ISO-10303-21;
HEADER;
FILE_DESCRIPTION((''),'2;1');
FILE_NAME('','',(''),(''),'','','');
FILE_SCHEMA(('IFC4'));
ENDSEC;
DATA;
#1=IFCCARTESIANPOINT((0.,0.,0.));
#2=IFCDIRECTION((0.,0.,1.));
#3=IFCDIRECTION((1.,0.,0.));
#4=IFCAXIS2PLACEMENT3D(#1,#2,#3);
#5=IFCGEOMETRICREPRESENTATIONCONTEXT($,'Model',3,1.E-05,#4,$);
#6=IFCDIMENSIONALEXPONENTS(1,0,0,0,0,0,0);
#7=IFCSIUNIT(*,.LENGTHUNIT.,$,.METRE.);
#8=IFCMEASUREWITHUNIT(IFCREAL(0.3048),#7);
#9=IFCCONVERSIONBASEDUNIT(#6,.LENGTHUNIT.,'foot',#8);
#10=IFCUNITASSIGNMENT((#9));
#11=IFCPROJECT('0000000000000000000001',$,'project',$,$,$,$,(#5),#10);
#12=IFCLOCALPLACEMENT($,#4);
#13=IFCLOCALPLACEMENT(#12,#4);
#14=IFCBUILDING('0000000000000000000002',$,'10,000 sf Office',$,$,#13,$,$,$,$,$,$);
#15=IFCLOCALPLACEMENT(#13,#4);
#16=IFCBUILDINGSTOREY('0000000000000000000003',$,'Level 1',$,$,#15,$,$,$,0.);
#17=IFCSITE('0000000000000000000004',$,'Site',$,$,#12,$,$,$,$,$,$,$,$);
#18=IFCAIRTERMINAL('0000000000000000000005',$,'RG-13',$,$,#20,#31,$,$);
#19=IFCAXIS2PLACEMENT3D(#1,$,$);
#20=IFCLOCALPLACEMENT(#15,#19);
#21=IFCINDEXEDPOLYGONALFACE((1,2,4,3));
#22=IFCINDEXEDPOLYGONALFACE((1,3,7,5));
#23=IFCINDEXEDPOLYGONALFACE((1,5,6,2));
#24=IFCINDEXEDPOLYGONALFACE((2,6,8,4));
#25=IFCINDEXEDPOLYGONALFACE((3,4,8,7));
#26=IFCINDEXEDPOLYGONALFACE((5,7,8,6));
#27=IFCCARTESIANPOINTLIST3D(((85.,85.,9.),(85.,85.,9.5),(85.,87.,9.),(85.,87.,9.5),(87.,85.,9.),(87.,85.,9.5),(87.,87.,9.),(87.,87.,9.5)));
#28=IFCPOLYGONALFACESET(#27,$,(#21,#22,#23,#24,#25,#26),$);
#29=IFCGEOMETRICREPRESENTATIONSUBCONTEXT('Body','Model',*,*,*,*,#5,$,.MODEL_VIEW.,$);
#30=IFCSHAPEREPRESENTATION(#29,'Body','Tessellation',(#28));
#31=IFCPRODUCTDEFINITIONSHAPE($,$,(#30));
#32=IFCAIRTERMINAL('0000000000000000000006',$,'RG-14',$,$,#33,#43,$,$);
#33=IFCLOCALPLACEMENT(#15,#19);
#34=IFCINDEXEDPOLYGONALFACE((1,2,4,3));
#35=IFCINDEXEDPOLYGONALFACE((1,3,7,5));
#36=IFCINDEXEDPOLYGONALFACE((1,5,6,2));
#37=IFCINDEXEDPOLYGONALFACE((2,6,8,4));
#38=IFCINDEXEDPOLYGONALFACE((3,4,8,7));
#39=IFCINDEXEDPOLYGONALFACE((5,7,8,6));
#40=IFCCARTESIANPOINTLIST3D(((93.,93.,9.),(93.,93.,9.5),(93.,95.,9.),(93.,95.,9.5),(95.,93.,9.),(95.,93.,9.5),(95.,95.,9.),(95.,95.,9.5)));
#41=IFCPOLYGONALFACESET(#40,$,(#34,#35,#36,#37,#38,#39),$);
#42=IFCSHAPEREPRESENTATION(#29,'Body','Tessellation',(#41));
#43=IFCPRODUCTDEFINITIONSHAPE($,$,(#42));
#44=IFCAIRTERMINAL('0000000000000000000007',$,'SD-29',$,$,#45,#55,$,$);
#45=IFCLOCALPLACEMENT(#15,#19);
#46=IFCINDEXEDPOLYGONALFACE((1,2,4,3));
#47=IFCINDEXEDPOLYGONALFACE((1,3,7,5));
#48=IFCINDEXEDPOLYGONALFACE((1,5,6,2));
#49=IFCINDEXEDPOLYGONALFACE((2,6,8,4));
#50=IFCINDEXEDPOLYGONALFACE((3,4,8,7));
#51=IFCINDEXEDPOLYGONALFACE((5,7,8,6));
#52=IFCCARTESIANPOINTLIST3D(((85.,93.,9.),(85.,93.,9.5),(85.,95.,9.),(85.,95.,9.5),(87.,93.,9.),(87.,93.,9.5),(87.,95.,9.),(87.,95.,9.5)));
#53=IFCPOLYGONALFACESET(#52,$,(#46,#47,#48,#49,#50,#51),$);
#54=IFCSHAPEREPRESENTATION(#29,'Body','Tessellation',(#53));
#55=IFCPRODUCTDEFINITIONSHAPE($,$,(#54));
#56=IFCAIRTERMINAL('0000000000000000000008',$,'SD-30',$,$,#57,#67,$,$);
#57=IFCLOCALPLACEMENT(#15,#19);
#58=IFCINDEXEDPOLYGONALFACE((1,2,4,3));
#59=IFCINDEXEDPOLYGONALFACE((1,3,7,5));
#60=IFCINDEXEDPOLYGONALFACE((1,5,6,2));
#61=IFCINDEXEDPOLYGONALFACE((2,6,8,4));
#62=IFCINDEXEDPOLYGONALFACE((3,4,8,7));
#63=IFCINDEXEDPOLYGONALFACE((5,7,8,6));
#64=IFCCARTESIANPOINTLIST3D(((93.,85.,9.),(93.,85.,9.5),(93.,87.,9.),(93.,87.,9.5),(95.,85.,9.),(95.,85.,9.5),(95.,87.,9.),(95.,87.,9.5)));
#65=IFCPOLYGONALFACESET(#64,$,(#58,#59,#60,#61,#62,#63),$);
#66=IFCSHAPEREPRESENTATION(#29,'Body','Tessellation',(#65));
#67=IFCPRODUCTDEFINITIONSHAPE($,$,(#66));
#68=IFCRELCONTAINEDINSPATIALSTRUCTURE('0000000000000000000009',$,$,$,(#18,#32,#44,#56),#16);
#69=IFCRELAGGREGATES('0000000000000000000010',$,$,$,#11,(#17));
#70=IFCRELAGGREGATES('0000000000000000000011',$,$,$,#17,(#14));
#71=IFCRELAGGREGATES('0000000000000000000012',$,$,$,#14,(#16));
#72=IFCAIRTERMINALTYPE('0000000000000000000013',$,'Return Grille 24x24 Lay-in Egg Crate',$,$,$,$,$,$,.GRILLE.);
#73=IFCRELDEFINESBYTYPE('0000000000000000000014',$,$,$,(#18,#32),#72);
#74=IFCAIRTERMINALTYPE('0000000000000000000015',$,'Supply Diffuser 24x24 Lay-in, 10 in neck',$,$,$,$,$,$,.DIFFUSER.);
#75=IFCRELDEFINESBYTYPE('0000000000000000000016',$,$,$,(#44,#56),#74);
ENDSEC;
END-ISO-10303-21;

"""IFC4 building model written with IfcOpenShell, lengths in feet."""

from ifc_helpers import new_model, entity, si_unit, converted_unit, frame, origin_with_axes, place, context, subcontext, project, spatial, rectangle, extrude, type_object, element, save


model = new_model("IFC4")

# Units and contexts
model_context = context("Model", 3, precision=1e-05, world=origin_with_axes())
body_context = subcontext(model_context, "Body", "Model", "MODEL_VIEW")
ifc_project = project(units=[converted_unit("LENGTHUNIT", "foot", entity("IfcReal", 0.3048), si_unit("LENGTHUNIT", "METRE"), dimensions=[1, 0, 0, 0, 0, 0, 0])], contexts=[model_context])

# Site, building, storey
site_placement = place(None, origin_with_axes())
site = spatial("IfcSite", under=ifc_project, at=site_placement, Name="Site")
building_placement = place(site_placement, origin_with_axes())
building = spatial("IfcBuilding", under=site, at=building_placement, Name="10,000 sf Office")
storey_placement = place(building_placement, origin_with_axes())
storey = spatial("IfcBuildingStorey", under=building, at=storey_placement, Name="Level 1", Elevation=0.0)

# Air terminals
air_terminal_type_1 = type_object("IfcAirTerminalType", Name="Return Grille 24x24 Lay-in Egg Crate", PredefinedType="GRILLE")
for number, where, z_axis, x_axis, name in (
    (1, (86.0, 86.0, 9.0), (0.0, 0.0, 1.0), (1.0, 0.0, 0.0), "RG-13"),
    (2, (94.0, 94.0, 9.0), (0.0, 0.0, 1.0), (1.0, 0.0, 0.0), "RG-14"),
):
    element("IfcAirTerminal", number, at=place(storey_placement, frame(where, z_axis=z_axis, x_axis=x_axis)), inside=storey, type_object=air_terminal_type_1, Name=name, context=body_context, shape_type="SweptSolid", body=[
        extrude(rectangle(XDim=2.0, YDim=2.0), None, (0.0, 0.0, 1.0), 0.5),
    ])
air_terminal_type_2 = type_object("IfcAirTerminalType", Name="Supply Diffuser 24x24 Lay-in, 10 in neck", PredefinedType="DIFFUSER")
for number, where, z_axis, x_axis, name in (
    (3, (86.0, 94.0, 9.0), (0.0, 0.0, 1.0), (1.0, 0.0, 0.0), "SD-29"),
    (4, (94.0, 86.0, 9.0), (0.0, 0.0, 1.0), (1.0, 0.0, 0.0), "SD-30"),
):
    element("IfcAirTerminal", number, at=place(storey_placement, frame(where, z_axis=z_axis, x_axis=x_axis)), inside=storey, type_object=air_terminal_type_2, Name=name, context=body_context, shape_type="SweptSolid", body=[
        extrude(rectangle(XDim=2.0, YDim=2.0), None, (0.0, 0.0, 1.0), 0.5),
    ])

save(model, "model.ifc")
